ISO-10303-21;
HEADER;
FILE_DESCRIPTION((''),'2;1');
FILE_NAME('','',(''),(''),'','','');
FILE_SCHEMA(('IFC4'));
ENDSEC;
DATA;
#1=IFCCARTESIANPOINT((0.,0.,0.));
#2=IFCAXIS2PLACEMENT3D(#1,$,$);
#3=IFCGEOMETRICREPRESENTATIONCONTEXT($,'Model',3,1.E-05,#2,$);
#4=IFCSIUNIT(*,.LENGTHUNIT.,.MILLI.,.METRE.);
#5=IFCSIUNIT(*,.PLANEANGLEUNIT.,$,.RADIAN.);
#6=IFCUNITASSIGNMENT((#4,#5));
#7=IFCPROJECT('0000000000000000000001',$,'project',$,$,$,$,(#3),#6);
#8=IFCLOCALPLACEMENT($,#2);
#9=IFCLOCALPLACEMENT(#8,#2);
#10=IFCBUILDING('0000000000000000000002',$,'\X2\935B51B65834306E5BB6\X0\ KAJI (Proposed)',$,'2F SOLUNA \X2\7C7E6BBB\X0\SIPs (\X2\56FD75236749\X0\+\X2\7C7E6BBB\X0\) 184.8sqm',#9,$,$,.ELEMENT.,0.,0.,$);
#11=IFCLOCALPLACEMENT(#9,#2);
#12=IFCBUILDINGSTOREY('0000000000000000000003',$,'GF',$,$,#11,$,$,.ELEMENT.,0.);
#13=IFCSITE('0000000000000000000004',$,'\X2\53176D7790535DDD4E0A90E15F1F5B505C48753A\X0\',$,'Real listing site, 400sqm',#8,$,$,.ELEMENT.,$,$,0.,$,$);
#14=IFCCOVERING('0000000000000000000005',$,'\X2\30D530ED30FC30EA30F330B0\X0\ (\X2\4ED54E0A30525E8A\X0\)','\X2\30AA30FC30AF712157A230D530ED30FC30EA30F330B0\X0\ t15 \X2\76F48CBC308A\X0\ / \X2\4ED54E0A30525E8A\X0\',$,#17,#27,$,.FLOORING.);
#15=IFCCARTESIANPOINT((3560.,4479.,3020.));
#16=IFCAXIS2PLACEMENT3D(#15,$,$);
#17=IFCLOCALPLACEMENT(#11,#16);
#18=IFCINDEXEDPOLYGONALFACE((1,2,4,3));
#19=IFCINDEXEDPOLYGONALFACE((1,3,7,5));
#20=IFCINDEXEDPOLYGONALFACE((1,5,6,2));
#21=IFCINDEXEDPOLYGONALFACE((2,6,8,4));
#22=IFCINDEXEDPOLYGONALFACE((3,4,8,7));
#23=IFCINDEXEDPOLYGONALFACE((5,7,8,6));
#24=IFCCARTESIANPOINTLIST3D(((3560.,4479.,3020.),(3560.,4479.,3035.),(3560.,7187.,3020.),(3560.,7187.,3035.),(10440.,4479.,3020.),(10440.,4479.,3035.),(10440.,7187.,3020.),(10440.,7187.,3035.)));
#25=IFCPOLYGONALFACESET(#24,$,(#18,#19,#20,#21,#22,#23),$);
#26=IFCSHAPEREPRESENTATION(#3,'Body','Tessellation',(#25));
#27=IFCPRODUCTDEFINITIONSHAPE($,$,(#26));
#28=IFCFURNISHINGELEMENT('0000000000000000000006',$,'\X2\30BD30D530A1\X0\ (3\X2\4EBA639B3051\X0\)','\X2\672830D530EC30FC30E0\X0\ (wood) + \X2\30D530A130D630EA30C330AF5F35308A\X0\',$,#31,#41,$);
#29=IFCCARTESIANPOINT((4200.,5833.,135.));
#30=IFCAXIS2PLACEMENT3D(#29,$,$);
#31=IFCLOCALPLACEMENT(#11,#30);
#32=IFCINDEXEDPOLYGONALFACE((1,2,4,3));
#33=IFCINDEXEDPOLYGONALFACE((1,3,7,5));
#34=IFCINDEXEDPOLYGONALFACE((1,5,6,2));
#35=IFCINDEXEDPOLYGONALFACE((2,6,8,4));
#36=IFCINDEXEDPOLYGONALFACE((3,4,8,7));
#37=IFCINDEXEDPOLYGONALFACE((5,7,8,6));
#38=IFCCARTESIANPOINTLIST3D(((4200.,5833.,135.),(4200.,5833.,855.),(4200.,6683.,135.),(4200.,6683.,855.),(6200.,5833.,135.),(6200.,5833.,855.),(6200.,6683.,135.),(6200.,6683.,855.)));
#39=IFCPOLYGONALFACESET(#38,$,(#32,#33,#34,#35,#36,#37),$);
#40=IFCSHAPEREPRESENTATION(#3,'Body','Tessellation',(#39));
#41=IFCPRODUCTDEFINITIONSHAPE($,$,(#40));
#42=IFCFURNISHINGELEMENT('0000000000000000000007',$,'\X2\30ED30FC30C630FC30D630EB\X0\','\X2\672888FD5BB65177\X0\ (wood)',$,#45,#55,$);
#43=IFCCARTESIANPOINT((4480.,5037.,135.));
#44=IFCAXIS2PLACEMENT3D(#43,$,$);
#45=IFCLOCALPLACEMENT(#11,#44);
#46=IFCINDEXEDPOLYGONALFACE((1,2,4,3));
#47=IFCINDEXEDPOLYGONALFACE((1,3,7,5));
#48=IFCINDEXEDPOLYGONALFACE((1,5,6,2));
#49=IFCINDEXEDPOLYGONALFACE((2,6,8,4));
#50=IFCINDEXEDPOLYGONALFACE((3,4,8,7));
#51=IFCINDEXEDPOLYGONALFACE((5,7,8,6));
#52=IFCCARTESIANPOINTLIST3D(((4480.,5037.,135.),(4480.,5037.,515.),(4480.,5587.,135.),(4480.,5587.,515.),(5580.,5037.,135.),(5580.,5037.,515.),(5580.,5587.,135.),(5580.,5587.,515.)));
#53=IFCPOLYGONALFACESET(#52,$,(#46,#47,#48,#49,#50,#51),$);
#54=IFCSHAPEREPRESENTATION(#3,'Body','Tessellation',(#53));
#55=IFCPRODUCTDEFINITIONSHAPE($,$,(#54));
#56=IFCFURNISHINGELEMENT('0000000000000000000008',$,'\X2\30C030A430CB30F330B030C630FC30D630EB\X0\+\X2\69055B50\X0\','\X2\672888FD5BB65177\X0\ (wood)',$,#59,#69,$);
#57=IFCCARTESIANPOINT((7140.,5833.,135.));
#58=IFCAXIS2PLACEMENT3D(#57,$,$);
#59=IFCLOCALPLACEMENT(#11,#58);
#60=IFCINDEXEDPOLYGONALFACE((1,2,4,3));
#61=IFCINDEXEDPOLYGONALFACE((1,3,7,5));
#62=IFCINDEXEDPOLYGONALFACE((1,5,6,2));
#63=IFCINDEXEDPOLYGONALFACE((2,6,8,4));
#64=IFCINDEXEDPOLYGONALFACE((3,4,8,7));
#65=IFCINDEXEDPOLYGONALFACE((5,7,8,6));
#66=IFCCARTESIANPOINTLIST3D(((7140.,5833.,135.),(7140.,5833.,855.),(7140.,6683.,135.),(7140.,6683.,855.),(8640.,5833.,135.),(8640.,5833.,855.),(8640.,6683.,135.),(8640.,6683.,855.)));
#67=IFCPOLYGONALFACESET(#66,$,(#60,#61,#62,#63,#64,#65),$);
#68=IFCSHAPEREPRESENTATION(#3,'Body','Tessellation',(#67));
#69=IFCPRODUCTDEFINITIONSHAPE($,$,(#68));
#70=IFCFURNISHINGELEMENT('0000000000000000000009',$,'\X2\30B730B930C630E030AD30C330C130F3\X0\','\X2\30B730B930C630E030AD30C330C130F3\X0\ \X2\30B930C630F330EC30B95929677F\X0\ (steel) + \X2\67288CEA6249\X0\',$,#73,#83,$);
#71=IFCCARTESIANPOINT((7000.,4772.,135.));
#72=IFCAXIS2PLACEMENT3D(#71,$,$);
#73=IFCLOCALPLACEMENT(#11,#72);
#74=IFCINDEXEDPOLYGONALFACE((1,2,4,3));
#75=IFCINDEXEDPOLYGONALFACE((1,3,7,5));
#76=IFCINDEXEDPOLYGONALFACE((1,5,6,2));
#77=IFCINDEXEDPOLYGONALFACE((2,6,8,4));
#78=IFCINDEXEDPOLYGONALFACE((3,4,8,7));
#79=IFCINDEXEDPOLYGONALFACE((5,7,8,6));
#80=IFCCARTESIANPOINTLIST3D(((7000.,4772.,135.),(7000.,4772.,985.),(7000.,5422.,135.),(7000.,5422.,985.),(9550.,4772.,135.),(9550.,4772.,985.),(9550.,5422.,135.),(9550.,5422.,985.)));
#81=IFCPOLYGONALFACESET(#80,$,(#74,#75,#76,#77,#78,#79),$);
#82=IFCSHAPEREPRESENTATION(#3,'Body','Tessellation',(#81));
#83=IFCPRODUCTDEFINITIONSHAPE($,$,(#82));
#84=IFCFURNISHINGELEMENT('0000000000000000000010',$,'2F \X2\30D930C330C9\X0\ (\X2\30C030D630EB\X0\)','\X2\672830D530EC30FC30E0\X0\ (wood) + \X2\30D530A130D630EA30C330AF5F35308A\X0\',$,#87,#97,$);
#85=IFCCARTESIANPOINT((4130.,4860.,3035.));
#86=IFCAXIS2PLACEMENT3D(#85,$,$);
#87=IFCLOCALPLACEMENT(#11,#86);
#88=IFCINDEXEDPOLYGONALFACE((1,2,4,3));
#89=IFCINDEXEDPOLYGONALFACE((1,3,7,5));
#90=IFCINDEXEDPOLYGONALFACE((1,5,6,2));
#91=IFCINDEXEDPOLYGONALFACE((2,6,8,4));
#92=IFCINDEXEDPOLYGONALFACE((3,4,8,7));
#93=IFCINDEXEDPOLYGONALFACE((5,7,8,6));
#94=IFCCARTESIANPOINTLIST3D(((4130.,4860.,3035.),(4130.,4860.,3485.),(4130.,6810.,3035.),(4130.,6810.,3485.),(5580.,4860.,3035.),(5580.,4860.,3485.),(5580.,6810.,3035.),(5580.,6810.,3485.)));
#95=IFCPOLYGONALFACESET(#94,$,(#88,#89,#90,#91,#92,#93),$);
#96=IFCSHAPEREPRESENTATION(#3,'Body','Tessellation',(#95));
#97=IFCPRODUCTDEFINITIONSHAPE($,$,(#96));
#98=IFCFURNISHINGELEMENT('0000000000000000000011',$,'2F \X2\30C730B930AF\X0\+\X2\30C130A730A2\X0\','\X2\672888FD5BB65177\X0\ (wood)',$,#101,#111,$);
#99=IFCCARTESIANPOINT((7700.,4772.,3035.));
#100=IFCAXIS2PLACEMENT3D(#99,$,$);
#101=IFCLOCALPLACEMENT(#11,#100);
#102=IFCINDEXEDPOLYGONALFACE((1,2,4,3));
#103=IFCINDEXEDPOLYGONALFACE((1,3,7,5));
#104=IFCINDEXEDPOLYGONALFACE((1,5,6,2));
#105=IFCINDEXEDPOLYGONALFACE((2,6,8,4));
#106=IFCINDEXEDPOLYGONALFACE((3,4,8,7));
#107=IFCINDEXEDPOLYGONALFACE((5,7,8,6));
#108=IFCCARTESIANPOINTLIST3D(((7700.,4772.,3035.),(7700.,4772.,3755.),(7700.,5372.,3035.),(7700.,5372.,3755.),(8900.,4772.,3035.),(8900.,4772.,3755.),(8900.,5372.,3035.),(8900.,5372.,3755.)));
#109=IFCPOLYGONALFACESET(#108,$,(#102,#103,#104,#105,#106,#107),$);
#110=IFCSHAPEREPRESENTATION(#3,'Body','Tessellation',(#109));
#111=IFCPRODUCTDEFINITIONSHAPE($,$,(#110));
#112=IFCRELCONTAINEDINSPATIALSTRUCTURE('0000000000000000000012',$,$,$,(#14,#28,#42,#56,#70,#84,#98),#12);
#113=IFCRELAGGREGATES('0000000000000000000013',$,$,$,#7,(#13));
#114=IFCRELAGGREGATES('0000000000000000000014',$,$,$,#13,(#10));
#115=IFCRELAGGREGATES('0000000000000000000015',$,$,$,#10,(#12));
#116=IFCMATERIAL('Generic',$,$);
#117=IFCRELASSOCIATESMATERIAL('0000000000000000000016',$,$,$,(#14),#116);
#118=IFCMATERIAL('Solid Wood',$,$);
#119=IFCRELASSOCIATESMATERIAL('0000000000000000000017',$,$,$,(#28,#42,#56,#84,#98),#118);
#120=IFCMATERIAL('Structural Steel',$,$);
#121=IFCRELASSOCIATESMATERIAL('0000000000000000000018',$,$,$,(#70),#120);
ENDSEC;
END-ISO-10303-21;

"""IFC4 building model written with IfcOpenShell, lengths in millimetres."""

from ifc_helpers import new_model, si_unit, frame, frame_2d, origin, place, context, project, spatial, rectangle, extrude, material, element, save


model = new_model("IFC4")

# Units and contexts
model_context = context("Model", 3, precision=1e-05, world=origin())
ifc_project = project(units=[si_unit("LENGTHUNIT", "METRE", prefix="MILLI"), si_unit("PLANEANGLEUNIT", "RADIAN")], contexts=[model_context])

# Site, building, storey
site_placement = place(None, origin())
site = spatial("IfcSite", under=ifc_project, at=site_placement, Name="北海道川上郡弟子屈町", ObjectType="Real listing site, 400sqm", CompositionType="ELEMENT", RefElevation=0.0)
building_placement = place(site_placement, origin())
building = spatial("IfcBuilding", under=site, at=building_placement, Name="鍛冶場の家 KAJI (Proposed)", ObjectType="2F SOLUNA 籾殻SIPs (国産杉+籾殻) 184.8sqm", CompositionType="ELEMENT", ElevationOfRefHeight=0.0, ElevationOfTerrain=0.0)
storey_placement = place(building_placement, origin())
storey = spatial("IfcBuildingStorey", under=building, at=storey_placement, Name="GF", CompositionType="ELEMENT", Elevation=0.0)

# Shared definitions
ifc_material_1 = material(Name="Solid Wood")

# Shared definitions
ifc_material_2 = material(Name="Generic")

# Shared definitions
ifc_material_3 = material(Name="Structural Steel")

# Covering
covering_placement = place(storey_placement, frame((3560.0, 4479.0, 3020.0)))
element("IfcCovering", 1, at=covering_placement, inside=storey, material=ifc_material_2, Name="フローリング (仕上げ床)", Description="オーク無垢フローリング t15 直貼り / 仕上げ床", PredefinedType="FLOORING", context=model_context, shape_type="SweptSolid", body=[
    extrude(rectangle(XDim=6880.0, YDim=2708.0, at=frame_2d((3440.0, 1354.0))), frame((3560.0, 4479.0, 3020.0)), (0.0, 0.0, 1.0), 15.0),
])

# Furnishing elements
furnishing_1_placement = place(storey_placement, frame((4200.0, 5833.0, 135.0)))
element("IfcFurnishingElement", 2, at=furnishing_1_placement, inside=storey, material=ifc_material_1, Name="ソファ (3人掛け)", Description="木フレーム (wood) + ファブリック張り", context=model_context, shape_type="SweptSolid", body=[
    extrude(rectangle(XDim=2000.0, YDim=850.0, at=frame_2d((1000.0, 425.0))), frame((4200.0, 5833.0, 135.0)), (0.0, 0.0, 1.0), 720.0),
])
furnishing_2_placement = place(storey_placement, frame((4480.0, 5037.0, 135.0)))
element("IfcFurnishingElement", 3, at=furnishing_2_placement, inside=storey, material=ifc_material_1, Name="ローテーブル", Description="木製家具 (wood)", context=model_context, shape_type="SweptSolid", body=[
    extrude(rectangle(XDim=1100.0, YDim=550.0, at=frame_2d((550.0, 275.0))), frame((4480.0, 5037.0, 135.0)), (0.0, 0.0, 1.0), 380.0),
])
furnishing_3_placement = place(storey_placement, frame((7140.0, 5833.0, 135.0)))
element("IfcFurnishingElement", 4, at=furnishing_3_placement, inside=storey, material=ifc_material_1, Name="ダイニングテーブル+椅子", Description="木製家具 (wood)", context=model_context, shape_type="SweptSolid", body=[
    extrude(rectangle(XDim=1500.0, YDim=850.0, at=frame_2d((750.0, 425.0))), frame((7140.0, 5833.0, 135.0)), (0.0, 0.0, 1.0), 720.0),
])
furnishing_4_placement = place(storey_placement, frame((7000.0, 4772.0, 135.0)))
element("IfcFurnishingElement", 5, at=furnishing_4_placement, inside=storey, material=ifc_material_3, Name="システムキッチン", Description="システムキッチン ステンレス天板 (steel) + 木質扉", context=model_context, shape_type="SweptSolid", body=[
    extrude(rectangle(XDim=2550.0, YDim=650.0, at=frame_2d((1275.0, 325.0))), frame((7000.0, 4772.0, 135.0)), (0.0, 0.0, 1.0), 850.0),
])
furnishing_5_placement = place(storey_placement, frame((4130.0, 4860.0, 3035.0)))
element("IfcFurnishingElement", 6, at=furnishing_5_placement, inside=storey, material=ifc_material_1, Name="2F ベッド (ダブル)", Description="木フレーム (wood) + ファブリック張り", context=model_context, shape_type="SweptSolid", body=[
    extrude(rectangle(XDim=1450.0, YDim=1950.0, at=frame_2d((725.0, 975.0))), frame((4130.0, 4860.0, 3035.0)), (0.0, 0.0, 1.0), 450.0),
])
furnishing_6_placement = place(storey_placement, frame((7700.0, 4772.0, 3035.0)))
element("IfcFurnishingElement", 7, at=furnishing_6_placement, inside=storey, material=ifc_material_1, Name="2F デスク+チェア", Description="木製家具 (wood)", context=model_context, shape_type="SweptSolid", body=[
    extrude(rectangle(XDim=1200.0, YDim=600.0, at=frame_2d((600.0, 300.0))), frame((7700.0, 4772.0, 3035.0)), (0.0, 0.0, 1.0), 720.0),
])

save(model, "model.ifc")
